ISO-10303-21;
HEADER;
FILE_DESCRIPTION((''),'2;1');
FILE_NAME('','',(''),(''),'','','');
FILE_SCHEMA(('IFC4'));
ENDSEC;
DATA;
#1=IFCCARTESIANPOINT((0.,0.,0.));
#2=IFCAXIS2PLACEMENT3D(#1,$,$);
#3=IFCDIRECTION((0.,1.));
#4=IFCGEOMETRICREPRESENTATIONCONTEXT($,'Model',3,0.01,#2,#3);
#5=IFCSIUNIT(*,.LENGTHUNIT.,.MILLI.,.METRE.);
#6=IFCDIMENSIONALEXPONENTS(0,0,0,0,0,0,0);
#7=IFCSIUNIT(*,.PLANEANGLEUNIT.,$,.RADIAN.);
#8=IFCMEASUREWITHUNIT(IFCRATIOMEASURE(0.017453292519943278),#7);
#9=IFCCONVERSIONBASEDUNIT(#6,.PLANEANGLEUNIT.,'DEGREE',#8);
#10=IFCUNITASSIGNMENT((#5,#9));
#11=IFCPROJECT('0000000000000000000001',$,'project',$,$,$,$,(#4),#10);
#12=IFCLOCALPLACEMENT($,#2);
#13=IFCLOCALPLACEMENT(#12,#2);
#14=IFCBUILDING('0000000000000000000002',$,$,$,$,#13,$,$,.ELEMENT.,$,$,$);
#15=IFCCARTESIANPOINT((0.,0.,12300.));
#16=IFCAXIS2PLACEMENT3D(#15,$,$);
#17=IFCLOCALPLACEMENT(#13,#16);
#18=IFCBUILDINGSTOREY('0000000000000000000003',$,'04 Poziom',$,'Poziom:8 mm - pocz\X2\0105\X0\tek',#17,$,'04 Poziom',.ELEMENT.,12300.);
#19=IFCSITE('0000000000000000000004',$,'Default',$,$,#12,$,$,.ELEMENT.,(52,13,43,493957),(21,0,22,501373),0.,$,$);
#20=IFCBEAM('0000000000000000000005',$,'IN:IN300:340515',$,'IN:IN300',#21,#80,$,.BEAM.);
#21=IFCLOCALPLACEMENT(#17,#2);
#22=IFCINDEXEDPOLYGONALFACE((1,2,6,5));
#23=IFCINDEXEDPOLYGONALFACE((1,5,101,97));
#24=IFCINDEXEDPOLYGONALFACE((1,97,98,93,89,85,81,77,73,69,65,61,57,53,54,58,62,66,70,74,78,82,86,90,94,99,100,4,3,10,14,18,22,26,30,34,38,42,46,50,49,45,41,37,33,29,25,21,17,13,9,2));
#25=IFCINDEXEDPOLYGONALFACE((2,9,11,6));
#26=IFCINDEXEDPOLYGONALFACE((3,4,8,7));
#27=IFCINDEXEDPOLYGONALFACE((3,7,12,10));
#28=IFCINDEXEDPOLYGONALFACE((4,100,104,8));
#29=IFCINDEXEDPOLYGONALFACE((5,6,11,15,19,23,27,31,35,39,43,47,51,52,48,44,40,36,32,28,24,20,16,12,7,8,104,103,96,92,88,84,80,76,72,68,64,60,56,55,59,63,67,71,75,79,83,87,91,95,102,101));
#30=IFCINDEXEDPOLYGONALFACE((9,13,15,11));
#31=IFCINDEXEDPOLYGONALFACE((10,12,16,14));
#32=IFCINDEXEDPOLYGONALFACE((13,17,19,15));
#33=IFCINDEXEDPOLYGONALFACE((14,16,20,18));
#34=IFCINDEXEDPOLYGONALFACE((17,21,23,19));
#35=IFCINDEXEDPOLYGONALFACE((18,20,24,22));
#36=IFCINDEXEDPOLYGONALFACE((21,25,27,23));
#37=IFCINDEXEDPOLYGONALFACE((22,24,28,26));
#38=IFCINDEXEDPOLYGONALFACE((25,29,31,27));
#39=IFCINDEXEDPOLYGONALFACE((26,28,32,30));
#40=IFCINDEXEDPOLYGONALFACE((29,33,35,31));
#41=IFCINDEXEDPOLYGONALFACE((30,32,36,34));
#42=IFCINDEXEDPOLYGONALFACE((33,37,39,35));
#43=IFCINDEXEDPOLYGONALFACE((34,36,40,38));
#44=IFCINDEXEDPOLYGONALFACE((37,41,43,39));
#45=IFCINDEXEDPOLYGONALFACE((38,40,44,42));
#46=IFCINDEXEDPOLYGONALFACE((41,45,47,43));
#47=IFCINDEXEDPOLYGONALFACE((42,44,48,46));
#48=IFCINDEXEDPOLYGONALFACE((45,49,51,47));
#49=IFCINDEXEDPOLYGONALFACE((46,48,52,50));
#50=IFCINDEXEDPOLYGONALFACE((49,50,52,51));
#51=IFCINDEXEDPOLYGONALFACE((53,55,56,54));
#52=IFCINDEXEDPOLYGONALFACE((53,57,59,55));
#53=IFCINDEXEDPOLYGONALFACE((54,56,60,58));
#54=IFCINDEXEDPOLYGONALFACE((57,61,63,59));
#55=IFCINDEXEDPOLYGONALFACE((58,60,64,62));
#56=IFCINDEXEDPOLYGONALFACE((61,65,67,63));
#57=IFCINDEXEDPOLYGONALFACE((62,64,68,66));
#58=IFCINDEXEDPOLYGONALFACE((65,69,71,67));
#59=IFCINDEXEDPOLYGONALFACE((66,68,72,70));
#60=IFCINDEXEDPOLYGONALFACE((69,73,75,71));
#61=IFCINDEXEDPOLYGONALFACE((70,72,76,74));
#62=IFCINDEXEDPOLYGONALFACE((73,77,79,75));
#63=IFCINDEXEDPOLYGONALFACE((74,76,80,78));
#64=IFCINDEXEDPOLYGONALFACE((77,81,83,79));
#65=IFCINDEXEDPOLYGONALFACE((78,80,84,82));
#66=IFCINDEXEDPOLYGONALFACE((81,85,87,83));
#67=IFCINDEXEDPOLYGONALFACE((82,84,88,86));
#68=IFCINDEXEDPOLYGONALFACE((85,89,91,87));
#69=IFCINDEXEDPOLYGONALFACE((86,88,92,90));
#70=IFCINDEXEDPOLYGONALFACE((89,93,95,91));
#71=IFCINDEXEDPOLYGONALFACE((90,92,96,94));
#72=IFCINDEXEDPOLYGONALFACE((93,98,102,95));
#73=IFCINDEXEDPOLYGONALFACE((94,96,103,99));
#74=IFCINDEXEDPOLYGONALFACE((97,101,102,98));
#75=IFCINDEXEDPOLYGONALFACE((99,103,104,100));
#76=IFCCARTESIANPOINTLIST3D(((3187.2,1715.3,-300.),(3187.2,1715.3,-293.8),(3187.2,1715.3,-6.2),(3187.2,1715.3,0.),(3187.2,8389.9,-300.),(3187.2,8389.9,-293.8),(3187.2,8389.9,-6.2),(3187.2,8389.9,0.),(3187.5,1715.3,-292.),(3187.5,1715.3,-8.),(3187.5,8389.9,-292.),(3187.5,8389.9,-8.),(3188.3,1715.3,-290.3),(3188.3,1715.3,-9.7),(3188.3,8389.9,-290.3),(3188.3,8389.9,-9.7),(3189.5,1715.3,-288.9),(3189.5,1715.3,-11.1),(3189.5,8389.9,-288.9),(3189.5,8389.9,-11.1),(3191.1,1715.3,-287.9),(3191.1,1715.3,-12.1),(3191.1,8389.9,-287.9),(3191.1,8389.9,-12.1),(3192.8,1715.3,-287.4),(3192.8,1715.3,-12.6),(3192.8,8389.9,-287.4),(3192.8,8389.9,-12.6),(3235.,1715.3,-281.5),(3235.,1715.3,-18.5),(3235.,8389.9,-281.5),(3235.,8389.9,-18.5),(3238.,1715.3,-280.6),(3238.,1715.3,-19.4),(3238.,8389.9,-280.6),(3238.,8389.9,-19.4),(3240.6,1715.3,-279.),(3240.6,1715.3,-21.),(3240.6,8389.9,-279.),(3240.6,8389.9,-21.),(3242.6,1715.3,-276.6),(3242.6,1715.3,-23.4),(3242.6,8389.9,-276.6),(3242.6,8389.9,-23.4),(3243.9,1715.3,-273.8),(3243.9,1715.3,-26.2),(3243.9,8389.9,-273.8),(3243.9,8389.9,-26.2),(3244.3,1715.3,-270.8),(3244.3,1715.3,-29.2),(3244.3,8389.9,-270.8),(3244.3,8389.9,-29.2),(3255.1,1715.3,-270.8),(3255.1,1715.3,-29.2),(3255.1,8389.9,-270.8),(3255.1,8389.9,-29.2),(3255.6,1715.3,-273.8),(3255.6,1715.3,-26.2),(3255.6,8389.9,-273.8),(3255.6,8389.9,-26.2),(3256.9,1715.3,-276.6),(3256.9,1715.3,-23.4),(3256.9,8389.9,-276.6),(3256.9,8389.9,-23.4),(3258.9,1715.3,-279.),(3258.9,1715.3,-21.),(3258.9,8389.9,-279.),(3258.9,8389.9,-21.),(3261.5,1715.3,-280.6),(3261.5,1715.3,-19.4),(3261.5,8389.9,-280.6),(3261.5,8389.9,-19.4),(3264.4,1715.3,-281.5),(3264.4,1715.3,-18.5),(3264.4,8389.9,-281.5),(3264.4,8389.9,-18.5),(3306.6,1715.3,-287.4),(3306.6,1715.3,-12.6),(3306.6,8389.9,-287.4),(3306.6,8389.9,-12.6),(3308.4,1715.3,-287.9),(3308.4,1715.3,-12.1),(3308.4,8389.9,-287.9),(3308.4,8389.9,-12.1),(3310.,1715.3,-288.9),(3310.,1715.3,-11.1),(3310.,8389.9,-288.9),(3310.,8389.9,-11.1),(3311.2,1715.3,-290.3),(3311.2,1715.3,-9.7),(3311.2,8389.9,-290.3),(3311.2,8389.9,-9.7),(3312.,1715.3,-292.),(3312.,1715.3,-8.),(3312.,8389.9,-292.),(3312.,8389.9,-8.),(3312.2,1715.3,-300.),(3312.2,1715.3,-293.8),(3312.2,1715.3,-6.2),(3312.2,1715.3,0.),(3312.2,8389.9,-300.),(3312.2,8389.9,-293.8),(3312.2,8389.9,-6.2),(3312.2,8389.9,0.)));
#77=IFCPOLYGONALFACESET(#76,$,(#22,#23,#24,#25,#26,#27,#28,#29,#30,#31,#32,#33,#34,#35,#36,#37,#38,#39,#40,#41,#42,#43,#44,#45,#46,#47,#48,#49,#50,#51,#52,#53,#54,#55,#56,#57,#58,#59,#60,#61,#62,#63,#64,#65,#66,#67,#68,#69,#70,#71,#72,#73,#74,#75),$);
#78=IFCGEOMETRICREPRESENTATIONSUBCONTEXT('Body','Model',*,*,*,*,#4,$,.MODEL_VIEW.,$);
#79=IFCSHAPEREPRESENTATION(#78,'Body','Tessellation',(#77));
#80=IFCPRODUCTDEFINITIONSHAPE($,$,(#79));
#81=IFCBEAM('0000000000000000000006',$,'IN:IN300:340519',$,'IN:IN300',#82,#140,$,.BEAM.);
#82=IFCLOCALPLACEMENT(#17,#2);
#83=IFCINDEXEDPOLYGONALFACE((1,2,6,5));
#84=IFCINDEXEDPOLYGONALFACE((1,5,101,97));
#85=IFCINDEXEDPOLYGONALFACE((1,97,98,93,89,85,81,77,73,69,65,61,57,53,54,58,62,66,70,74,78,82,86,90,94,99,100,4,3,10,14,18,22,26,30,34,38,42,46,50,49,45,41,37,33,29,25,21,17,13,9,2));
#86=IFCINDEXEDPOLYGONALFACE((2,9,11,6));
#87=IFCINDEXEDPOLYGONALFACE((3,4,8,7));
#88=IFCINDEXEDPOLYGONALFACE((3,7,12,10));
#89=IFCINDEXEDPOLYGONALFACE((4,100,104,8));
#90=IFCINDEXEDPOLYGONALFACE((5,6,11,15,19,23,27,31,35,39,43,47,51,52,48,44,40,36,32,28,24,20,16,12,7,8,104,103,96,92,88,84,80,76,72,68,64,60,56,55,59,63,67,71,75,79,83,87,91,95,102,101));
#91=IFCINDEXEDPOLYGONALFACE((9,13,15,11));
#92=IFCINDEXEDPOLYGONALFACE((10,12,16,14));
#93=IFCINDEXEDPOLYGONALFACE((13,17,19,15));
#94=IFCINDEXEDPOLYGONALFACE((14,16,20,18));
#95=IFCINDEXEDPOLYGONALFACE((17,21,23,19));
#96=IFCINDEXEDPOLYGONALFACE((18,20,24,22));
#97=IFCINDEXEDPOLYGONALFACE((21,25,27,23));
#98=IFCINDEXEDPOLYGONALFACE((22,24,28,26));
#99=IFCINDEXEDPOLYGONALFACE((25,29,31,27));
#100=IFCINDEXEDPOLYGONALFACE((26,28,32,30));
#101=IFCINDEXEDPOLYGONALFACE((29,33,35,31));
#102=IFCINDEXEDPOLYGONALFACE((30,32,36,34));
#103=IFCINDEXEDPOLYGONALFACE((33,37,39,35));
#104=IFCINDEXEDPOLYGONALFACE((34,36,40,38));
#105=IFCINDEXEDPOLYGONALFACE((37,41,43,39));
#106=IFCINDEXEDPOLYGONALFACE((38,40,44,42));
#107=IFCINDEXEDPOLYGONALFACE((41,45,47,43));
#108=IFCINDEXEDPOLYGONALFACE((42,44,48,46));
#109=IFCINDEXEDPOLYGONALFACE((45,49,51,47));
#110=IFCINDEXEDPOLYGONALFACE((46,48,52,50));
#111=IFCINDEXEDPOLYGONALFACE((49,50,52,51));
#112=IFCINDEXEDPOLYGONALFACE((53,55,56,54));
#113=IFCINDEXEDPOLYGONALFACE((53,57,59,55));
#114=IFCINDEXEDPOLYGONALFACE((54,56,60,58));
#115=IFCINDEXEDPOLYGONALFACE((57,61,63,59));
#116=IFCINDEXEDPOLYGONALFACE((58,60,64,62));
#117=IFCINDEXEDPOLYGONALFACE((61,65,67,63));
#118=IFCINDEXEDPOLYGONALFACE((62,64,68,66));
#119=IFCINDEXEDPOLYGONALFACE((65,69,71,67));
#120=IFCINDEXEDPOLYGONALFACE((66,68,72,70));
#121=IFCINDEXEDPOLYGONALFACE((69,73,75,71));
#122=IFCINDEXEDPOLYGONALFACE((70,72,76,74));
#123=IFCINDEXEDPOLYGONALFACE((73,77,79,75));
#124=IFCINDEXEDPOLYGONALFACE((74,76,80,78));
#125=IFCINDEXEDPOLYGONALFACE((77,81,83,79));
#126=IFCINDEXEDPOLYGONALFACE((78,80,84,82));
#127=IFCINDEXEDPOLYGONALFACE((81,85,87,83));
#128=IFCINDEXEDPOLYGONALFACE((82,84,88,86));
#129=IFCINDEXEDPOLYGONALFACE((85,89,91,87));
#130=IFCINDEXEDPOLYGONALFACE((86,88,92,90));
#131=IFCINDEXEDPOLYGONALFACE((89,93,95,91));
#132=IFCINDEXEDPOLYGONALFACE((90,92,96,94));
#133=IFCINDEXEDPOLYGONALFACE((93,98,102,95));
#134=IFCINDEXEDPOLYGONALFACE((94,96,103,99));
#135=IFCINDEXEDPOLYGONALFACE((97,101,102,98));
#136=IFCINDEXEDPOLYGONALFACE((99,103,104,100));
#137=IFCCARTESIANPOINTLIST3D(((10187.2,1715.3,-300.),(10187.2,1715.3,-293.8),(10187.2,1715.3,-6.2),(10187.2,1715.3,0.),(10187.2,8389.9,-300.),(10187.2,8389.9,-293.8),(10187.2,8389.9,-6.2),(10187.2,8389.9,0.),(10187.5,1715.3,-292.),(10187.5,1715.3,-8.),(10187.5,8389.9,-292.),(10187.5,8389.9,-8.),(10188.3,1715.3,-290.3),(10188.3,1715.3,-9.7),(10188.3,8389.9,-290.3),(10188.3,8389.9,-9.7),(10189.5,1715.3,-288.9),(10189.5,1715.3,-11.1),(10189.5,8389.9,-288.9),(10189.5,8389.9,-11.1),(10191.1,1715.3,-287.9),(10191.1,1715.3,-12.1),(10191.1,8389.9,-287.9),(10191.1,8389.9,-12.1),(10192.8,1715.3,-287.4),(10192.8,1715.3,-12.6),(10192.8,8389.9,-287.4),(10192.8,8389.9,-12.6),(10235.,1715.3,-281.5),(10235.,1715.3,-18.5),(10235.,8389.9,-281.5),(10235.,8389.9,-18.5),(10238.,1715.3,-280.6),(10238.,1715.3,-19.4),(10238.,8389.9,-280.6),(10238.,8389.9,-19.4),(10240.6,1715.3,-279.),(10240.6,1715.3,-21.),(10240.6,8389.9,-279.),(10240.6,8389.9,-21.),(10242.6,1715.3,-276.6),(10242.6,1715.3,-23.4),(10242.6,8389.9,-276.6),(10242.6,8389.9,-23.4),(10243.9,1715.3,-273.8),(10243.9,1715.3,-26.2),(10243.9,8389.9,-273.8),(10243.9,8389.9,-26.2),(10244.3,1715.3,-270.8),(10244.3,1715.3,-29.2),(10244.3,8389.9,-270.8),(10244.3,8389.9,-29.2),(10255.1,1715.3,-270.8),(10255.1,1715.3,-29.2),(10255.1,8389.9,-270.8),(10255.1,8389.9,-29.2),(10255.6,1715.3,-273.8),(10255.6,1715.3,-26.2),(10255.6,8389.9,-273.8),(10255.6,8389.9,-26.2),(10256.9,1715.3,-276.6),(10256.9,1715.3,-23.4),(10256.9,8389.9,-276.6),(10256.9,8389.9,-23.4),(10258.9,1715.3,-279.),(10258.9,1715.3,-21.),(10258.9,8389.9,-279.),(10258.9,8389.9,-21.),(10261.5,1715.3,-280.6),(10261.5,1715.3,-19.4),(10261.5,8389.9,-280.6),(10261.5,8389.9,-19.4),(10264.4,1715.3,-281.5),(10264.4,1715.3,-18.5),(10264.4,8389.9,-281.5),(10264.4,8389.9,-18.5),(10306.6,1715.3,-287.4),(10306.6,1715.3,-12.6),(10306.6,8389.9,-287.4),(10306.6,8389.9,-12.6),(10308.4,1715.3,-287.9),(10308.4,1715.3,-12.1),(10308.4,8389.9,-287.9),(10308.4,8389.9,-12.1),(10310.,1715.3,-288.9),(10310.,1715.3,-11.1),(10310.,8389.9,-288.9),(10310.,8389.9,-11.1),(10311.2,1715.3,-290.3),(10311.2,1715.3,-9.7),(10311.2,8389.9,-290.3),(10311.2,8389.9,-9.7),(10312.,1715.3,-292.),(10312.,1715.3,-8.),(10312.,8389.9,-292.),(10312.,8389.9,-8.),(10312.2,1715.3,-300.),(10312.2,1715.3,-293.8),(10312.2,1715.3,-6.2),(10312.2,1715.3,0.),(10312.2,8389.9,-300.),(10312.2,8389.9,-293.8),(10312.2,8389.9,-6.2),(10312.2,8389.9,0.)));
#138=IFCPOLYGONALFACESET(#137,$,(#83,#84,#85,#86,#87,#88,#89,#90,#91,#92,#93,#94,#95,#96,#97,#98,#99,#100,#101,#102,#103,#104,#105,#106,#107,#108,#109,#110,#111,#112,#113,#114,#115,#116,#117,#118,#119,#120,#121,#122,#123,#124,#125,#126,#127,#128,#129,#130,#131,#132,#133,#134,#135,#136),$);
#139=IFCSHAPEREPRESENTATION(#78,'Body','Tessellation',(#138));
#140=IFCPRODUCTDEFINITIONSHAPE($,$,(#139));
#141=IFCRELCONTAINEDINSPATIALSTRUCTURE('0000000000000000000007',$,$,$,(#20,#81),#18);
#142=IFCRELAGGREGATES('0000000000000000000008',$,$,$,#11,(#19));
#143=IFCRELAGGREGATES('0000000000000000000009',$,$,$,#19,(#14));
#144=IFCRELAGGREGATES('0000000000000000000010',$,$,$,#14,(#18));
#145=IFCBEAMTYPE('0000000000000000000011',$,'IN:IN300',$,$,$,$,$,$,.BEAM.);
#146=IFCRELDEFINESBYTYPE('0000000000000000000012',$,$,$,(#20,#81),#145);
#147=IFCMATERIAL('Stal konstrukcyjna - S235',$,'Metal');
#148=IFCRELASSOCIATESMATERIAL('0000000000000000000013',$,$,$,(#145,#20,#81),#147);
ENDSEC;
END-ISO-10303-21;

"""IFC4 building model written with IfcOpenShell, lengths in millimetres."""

from ifc_helpers import new_model, entity, si_unit, converted_unit, direction, frame, origin, place, context, subcontext, project, spatial, line, arc, indexed_curve, outline, extrude, source, transform, mapped, material, type_object, type_shapes, element, save


model = new_model("IFC4")

# Units and contexts
model_context = context("Model", 3, precision=0.01, world=origin(), true_north=direction((0.0, 1.0)))
body_context = subcontext(model_context, "Body", "Model", "MODEL_VIEW")
ifc_project = project(units=[si_unit("LENGTHUNIT", "METRE", prefix="MILLI"), converted_unit("PLANEANGLEUNIT", "DEGREE", entity("IfcRatioMeasure", 0.017453292519943278), si_unit("PLANEANGLEUNIT", "RADIAN"), dimensions=[0, 0, 0, 0, 0, 0, 0])], contexts=[model_context])

# Site, building, storey
site_placement = place(None, origin())
site = spatial("IfcSite", under=ifc_project, at=site_placement, Name="Default", CompositionType="ELEMENT", RefLatitude=(52, 13, 43, 493957), RefLongitude=(21, 0, 22, 501373), RefElevation=0.0)
building_placement = place(site_placement, origin())
building = spatial("IfcBuilding", under=site, at=building_placement, CompositionType="ELEMENT")
storey_placement = place(building_placement, frame((0.0, 0.0, 12300.0)))
storey = spatial("IfcBuildingStorey", under=building, at=storey_placement, Name="04 Poziom", ObjectType="Poziom:8 mm - początek", LongName="04 Poziom", CompositionType="ELEMENT", Elevation=12300.0)

# Shared definitions
ifc_material_1 = material(Name="Stal konstrukcyjna - S235", Category="Metal")

# Beams
beam_type_1 = type_object("IfcBeamType", Name="IN:IN300", PredefinedType="BEAM", material=ifc_material_1)
shared_shape_1 = source(origin(), body_context, "Body", "SweptSolid", [
    extrude(outline(indexed_curve([(143.8, -62.5), (150.0, -62.5), (150.0, 62.5), (143.8, 62.5), (139.6, 60.9), (137.4, 56.9), (131.5, 14.7), (127.9, 8.1), (120.8, 5.4), (-120.8, 5.4), (-127.9, 8.1), (-131.5, 14.7), (-137.4, 56.9), (-139.6, 60.9), (-143.8, 62.5), (-150.0, 62.5), (-150.0, -62.5), (-143.8, -62.5), (-139.6, -60.9), (-137.4, -56.9), (-131.5, -14.7), (-127.9, -8.1), (-120.8, -5.4), (120.8, -5.4), (127.9, -8.1), (131.5, -14.7), (137.4, -56.9), (139.6, -60.9)], segments=[line(1, 2, 3, 4), arc(4, 5, 6), line(6, 7), arc(7, 8, 9), line(9, 10), arc(10, 11, 12), line(12, 13), arc(13, 14, 15), line(15, 16, 17, 18), arc(18, 19, 20), line(20, 21), arc(21, 22, 23), line(23, 24), arc(24, 25, 26), line(26, 27), arc(27, 28, 1)], self_intersect=False)), frame((-3337.3, 0.0, 0.0), z_axis=(1.0, 0.0, 0.0), x_axis=(0.0, 0.0, -1.0)), (0.0, 0.0, 1.0), 6674.6),
])
type_shapes(beam_type_1, [shared_shape_1])
for number, where, z_axis, x_axis, name in (
    (1, (3249.7, 5052.6, -150.0), (0.0, 0.0, 1.0), (0.0, -1.0, 0.0), "IN:IN300:340515"),
    (2, (10249.7, 5052.6, -150.0), (0.0, 0.0, 1.0), (0.0, -1.0, 0.0), "IN:IN300:340519"),
):
    element("IfcBeam", number, at=place(storey_placement, frame(where, z_axis=z_axis, x_axis=x_axis)), inside=storey, type_object=beam_type_1, material=ifc_material_1, Name=name, ObjectType="IN:IN300", PredefinedType="BEAM", context=body_context, shape_type="MappedRepresentation", body=[
        mapped(shared_shape_1, transform((0.0, 0.0, 0.0), scale=1.0)),
    ])

save(model, "model.ifc")
